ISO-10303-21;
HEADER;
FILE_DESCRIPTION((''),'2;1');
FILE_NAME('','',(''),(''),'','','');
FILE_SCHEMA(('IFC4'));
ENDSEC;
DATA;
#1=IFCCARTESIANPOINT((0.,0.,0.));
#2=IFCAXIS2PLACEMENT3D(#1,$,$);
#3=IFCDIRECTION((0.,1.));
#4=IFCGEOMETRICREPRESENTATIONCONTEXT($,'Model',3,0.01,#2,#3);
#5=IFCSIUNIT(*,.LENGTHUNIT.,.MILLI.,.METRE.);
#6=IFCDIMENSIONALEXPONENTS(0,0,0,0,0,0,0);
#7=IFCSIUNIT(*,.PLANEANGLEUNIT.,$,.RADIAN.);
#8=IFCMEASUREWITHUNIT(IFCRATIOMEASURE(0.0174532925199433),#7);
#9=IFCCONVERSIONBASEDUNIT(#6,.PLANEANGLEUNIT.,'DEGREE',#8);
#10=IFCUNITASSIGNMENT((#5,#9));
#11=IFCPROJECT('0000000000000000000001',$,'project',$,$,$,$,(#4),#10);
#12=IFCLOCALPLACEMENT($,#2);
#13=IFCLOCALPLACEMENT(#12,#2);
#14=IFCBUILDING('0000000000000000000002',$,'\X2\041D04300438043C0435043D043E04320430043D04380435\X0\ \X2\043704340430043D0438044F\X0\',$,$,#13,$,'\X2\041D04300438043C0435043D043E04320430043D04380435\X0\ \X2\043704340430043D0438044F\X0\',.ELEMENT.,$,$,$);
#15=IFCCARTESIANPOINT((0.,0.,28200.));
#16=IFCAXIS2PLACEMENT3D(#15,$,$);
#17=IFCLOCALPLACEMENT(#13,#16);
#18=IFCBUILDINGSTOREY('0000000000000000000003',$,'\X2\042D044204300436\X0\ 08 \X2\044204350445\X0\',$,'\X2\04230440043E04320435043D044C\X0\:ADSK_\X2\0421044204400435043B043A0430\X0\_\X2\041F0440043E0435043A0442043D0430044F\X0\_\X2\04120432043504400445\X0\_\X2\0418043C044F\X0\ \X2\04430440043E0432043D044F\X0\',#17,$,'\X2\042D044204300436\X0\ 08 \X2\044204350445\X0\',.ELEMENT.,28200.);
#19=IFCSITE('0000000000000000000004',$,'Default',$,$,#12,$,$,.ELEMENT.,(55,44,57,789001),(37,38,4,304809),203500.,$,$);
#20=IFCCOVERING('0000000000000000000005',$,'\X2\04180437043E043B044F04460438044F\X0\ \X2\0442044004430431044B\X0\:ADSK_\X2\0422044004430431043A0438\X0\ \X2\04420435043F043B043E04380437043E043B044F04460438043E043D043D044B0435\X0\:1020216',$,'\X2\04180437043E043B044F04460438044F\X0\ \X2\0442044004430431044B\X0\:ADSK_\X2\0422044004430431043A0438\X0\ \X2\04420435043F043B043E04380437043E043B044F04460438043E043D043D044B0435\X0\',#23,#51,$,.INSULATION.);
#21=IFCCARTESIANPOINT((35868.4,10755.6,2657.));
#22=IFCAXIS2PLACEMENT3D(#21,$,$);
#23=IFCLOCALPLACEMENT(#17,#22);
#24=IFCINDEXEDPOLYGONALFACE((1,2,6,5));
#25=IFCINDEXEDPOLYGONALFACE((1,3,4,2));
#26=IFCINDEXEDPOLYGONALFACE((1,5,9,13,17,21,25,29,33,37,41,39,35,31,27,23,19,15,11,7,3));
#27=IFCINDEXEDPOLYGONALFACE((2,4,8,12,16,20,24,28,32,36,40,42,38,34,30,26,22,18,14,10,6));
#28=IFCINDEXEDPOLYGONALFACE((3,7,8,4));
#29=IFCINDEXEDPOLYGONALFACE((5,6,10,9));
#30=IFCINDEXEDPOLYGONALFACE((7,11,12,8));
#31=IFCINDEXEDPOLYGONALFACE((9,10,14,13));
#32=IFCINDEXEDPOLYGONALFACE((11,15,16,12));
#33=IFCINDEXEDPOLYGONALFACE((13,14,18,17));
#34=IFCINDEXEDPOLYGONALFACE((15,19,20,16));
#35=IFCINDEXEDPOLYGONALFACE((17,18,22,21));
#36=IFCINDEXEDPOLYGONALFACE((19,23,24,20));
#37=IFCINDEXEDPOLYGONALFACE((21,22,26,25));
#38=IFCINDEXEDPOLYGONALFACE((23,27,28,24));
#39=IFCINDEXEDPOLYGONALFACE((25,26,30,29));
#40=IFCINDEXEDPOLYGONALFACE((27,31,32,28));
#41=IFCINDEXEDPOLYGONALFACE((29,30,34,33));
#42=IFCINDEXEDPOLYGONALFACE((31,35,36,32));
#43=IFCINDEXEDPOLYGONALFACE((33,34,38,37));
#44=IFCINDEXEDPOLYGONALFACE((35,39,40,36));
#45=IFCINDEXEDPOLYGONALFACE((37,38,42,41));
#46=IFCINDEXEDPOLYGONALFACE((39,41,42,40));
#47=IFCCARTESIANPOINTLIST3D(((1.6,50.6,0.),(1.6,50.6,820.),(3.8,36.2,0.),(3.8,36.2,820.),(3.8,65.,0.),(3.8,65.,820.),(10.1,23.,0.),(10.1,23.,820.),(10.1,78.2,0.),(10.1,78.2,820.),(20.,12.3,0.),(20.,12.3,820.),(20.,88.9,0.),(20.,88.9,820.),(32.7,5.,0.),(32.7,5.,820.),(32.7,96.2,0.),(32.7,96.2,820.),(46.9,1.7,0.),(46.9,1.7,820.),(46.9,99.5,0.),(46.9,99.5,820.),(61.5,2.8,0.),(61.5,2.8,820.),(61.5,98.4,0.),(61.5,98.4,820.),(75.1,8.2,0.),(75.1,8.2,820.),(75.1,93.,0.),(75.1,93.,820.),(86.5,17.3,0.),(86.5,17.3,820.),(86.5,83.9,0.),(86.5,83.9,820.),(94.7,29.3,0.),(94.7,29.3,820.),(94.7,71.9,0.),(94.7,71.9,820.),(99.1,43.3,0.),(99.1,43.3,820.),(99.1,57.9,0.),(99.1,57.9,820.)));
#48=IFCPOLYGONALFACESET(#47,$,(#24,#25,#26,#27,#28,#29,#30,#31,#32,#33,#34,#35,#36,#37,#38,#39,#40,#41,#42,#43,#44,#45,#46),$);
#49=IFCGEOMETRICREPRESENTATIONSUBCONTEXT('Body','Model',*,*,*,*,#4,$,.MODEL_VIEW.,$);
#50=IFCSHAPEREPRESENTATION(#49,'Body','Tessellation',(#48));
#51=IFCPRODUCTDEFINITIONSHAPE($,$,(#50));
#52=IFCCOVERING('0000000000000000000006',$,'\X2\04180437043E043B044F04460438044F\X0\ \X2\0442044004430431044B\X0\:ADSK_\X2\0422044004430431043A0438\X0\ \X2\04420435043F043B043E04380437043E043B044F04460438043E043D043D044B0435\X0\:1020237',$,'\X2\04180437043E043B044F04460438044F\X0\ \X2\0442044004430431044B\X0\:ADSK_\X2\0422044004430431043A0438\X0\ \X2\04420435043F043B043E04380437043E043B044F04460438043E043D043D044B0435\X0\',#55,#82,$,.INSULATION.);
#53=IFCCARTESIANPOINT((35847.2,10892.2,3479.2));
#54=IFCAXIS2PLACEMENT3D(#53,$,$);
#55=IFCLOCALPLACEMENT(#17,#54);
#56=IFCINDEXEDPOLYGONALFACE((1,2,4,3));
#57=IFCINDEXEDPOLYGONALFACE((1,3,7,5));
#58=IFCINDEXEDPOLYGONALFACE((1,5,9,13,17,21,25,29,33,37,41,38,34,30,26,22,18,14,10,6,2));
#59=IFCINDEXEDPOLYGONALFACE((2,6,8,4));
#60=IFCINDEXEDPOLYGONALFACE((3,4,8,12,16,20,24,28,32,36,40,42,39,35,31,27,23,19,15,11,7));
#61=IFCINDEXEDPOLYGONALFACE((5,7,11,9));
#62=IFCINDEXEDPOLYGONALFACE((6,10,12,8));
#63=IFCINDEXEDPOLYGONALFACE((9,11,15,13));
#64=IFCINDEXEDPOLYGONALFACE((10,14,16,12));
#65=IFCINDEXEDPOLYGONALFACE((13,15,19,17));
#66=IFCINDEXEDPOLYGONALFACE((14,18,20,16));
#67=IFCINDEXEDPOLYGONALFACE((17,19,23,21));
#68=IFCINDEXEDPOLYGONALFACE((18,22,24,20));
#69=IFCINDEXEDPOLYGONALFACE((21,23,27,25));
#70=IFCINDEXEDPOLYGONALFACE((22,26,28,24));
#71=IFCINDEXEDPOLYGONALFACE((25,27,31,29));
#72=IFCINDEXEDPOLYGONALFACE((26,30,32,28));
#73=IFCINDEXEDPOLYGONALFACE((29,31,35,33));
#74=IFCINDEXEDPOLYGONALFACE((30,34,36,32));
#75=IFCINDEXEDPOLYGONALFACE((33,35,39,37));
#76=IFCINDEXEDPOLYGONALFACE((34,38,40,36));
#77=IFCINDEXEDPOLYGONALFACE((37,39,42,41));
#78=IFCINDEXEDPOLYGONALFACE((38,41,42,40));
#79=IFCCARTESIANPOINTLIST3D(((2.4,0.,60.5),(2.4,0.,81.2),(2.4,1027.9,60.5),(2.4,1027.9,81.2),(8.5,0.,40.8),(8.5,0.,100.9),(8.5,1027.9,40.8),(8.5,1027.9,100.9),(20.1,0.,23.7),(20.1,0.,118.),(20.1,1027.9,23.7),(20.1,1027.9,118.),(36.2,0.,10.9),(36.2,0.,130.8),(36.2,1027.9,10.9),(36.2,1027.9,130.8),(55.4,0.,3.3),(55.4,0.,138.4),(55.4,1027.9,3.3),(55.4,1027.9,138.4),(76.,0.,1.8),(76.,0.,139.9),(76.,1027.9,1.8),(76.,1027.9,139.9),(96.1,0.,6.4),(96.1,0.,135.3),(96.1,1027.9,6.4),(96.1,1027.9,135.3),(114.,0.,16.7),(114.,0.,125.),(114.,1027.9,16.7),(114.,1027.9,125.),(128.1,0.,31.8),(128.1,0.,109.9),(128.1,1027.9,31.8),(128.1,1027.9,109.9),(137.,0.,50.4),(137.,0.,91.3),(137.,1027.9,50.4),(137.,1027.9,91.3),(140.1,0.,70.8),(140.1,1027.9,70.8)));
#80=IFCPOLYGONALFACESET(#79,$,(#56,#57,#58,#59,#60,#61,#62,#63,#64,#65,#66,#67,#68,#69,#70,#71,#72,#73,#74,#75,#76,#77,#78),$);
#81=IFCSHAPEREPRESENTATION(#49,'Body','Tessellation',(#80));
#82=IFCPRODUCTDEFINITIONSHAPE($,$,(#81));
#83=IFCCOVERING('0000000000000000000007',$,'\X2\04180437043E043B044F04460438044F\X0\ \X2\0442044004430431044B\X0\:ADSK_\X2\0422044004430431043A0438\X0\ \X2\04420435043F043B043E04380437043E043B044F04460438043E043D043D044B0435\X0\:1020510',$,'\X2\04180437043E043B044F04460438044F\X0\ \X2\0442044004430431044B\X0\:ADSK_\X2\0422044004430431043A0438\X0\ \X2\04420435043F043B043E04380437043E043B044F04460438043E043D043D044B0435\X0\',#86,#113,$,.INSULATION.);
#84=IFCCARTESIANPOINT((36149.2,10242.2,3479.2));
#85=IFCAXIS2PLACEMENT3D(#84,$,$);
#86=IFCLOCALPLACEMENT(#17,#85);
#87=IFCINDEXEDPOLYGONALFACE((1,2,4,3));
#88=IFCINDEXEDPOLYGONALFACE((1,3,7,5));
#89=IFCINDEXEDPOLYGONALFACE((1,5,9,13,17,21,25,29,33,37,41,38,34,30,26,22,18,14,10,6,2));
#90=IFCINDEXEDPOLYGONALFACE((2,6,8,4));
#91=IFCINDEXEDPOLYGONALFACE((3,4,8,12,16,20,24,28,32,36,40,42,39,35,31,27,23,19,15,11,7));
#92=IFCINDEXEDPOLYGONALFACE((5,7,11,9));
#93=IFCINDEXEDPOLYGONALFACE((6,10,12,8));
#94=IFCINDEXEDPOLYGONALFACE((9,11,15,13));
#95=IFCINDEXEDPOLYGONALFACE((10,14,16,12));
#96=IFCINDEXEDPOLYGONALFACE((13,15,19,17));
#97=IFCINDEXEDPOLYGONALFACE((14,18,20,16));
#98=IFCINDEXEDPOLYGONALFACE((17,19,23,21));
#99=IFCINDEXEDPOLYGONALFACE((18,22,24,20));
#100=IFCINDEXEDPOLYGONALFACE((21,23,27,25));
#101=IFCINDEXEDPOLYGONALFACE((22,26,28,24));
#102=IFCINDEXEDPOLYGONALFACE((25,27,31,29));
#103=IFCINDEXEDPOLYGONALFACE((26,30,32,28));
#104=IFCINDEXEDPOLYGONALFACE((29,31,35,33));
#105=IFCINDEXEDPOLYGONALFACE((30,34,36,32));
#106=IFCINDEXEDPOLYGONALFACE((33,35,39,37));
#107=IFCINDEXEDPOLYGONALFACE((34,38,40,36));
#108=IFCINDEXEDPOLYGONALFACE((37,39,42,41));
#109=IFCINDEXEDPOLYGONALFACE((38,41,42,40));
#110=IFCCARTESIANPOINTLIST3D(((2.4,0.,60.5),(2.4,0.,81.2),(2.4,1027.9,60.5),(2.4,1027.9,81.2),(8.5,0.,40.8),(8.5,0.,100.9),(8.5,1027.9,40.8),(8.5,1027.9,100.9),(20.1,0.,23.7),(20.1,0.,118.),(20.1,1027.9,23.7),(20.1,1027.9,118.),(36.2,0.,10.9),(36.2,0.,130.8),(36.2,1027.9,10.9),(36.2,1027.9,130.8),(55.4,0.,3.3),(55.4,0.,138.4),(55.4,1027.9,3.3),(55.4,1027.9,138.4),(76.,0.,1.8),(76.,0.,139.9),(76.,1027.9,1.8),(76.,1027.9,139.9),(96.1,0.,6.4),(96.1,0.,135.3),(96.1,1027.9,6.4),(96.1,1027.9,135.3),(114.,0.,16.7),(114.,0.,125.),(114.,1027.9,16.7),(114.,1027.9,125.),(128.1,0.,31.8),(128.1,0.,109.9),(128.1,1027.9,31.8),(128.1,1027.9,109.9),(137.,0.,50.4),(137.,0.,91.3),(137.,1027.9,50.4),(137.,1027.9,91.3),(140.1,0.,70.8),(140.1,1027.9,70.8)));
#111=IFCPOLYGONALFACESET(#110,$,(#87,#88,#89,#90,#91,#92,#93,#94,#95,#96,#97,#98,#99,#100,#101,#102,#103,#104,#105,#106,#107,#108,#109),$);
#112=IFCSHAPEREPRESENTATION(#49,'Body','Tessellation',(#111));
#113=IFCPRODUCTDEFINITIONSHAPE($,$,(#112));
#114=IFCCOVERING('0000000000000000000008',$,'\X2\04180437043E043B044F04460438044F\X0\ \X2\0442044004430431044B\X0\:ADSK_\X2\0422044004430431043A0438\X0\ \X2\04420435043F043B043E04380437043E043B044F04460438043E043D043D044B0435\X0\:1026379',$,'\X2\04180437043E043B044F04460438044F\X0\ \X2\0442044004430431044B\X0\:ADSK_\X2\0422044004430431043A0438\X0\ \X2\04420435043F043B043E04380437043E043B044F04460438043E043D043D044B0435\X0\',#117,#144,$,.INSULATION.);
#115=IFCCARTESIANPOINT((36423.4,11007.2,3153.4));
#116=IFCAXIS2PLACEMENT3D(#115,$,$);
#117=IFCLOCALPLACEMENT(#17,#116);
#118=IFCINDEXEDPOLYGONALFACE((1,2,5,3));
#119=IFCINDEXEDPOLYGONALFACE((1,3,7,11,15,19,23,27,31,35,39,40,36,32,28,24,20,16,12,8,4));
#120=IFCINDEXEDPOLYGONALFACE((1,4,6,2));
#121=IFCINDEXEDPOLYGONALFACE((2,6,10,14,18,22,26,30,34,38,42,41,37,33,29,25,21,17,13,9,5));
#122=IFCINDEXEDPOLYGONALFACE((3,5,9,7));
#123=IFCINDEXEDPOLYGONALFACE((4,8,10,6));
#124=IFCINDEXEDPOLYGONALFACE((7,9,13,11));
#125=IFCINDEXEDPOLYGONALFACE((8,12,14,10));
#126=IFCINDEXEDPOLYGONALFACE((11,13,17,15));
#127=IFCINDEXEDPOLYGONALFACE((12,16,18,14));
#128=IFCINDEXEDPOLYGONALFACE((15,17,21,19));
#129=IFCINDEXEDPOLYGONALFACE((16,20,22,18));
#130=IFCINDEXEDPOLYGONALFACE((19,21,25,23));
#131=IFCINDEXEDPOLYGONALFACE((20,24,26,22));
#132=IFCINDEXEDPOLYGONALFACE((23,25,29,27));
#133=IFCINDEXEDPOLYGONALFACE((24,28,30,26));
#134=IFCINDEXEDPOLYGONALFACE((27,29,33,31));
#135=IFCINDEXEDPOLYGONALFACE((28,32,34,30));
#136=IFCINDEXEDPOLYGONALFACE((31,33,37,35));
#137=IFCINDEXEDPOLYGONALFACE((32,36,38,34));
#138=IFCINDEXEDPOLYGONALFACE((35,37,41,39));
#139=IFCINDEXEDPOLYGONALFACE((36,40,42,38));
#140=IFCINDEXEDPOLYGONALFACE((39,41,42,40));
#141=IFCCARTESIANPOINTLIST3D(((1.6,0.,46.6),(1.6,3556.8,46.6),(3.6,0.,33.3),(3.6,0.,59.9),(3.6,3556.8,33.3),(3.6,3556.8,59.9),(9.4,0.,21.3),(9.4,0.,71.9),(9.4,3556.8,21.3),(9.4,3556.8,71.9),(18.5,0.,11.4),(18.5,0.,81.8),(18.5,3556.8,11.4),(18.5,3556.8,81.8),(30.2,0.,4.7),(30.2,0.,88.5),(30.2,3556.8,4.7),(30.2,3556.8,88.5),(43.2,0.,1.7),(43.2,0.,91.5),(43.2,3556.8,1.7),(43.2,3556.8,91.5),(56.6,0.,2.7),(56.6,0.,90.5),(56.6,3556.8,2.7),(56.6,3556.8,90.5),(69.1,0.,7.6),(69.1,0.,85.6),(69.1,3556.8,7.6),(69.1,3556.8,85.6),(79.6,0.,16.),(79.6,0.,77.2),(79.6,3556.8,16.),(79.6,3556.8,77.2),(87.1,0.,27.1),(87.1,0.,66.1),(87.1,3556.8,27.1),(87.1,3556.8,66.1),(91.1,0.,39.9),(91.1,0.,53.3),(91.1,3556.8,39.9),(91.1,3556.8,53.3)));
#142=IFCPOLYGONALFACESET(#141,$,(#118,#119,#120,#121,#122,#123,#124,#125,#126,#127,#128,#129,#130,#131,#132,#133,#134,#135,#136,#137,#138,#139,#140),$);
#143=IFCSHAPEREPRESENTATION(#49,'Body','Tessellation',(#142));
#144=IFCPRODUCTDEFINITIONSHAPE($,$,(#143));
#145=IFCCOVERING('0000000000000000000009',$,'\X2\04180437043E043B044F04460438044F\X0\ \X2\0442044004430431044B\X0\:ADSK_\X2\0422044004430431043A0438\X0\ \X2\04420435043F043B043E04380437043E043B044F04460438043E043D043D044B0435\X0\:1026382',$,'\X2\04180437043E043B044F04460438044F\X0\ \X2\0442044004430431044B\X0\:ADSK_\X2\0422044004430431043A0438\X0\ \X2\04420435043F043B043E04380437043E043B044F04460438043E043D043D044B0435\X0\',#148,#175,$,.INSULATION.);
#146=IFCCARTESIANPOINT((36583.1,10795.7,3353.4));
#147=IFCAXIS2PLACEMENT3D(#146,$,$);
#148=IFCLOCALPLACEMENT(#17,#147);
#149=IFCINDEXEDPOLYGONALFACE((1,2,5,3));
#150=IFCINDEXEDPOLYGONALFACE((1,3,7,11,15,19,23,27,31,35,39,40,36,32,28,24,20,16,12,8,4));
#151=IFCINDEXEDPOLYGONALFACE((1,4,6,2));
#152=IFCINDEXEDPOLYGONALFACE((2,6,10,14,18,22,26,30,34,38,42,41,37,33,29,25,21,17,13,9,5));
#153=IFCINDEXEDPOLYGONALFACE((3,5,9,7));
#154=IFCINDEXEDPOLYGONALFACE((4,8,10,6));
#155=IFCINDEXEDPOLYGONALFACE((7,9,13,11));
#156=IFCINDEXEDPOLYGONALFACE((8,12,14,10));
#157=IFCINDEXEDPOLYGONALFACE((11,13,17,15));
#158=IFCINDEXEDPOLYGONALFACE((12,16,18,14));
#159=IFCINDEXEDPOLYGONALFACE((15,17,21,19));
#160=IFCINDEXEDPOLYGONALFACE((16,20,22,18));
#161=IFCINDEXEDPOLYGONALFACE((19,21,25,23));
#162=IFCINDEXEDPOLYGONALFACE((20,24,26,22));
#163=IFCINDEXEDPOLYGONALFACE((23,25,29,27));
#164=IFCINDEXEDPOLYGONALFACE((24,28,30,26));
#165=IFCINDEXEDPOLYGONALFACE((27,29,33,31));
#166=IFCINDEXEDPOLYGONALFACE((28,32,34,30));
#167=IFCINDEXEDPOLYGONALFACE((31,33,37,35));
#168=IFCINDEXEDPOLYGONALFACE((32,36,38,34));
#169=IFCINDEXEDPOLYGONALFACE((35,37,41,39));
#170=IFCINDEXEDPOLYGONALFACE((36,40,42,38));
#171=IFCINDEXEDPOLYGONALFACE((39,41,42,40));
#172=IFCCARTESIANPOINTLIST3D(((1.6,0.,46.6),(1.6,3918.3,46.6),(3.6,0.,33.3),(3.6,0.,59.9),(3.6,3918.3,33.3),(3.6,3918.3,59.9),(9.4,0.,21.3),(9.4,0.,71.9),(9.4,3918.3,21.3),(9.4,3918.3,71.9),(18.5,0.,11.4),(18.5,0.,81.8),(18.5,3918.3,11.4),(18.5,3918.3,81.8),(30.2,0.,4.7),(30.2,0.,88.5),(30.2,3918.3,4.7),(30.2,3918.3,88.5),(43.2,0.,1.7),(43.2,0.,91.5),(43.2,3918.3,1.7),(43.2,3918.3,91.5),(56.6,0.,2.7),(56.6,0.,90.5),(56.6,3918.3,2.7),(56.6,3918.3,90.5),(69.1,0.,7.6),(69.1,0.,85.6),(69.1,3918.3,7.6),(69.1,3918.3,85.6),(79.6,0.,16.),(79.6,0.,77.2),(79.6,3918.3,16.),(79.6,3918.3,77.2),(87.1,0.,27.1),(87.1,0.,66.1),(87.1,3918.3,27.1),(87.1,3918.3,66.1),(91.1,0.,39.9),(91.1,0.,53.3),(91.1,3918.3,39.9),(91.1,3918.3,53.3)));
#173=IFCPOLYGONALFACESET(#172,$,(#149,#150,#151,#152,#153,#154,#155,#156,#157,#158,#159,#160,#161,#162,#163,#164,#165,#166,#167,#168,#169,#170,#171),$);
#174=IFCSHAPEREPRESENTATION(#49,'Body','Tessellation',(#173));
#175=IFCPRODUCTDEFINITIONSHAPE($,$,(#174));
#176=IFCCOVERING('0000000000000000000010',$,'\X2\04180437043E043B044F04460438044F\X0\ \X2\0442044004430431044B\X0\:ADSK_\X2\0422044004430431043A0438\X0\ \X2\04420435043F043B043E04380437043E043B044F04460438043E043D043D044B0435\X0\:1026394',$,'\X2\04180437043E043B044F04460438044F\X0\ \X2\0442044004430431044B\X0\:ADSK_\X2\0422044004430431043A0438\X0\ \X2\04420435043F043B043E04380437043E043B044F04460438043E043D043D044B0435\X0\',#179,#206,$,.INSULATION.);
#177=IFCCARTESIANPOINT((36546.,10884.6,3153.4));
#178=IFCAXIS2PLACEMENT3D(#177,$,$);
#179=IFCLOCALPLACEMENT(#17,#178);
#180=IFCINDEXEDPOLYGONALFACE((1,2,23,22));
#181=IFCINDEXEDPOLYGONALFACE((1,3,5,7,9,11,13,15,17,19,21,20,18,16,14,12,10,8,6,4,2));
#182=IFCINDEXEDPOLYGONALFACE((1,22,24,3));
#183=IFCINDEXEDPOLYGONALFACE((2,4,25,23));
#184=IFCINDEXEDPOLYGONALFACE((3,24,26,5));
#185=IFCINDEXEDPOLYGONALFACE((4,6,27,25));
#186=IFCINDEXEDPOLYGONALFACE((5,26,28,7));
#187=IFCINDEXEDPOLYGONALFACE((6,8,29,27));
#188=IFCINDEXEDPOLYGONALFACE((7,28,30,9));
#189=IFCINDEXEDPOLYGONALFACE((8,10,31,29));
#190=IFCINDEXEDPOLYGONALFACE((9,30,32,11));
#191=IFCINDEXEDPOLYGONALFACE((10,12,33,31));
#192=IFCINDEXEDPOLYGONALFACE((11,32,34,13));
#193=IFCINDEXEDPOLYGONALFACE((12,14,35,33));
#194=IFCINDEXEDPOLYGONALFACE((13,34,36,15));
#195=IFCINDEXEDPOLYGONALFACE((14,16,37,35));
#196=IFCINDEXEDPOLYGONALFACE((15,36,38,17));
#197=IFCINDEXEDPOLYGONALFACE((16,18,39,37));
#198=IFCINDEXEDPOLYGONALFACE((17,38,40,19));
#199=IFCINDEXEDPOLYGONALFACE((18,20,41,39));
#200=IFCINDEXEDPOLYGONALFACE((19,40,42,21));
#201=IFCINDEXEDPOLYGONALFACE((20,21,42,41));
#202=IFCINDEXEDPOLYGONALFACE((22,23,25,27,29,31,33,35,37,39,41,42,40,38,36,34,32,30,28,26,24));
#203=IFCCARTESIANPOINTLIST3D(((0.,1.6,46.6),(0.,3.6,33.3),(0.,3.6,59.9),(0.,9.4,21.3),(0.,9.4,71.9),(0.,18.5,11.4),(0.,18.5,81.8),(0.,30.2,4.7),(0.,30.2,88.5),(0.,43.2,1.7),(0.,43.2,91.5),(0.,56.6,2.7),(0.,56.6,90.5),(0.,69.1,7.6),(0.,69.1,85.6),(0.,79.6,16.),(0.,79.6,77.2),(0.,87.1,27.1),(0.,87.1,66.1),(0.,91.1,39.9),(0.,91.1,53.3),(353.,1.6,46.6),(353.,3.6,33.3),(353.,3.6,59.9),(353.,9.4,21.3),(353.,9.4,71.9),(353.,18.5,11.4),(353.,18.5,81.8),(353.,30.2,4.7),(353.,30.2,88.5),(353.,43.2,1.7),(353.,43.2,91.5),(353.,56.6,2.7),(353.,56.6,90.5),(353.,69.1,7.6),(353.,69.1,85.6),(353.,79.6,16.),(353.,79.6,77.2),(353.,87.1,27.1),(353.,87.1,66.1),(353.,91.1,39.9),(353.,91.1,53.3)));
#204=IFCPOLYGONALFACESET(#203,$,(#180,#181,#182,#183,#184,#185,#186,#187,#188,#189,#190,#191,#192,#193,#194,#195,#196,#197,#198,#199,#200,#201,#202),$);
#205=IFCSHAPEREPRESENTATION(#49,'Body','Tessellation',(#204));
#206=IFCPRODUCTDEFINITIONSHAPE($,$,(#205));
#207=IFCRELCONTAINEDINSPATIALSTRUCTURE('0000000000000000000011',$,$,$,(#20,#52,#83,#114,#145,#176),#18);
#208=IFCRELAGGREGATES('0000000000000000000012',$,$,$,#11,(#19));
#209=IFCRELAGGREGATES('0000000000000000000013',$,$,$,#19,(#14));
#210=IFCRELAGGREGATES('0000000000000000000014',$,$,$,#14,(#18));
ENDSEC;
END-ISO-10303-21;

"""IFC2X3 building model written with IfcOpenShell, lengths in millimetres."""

from ifc_helpers import new_model, entity, si_unit, converted_unit, direction, frame, origin, origin_2d_with_axis, place, context, subcontext, project, spatial, circle, extrude, element, save


model = new_model("IFC2X3")

# Units and contexts
model_context = context("Model", 3, precision=0.01, world=origin(), true_north=direction((0.0, 1.0)))
body_context = subcontext(model_context, "Body", "Model", "MODEL_VIEW")
ifc_project = project(units=[si_unit("LENGTHUNIT", "METRE", prefix="MILLI"), converted_unit("PLANEANGLEUNIT", "DEGREE", entity("IfcRatioMeasure", 0.0174532925199433), si_unit("PLANEANGLEUNIT", "RADIAN"), dimensions=[0, 0, 0, 0, 0, 0, 0])], contexts=[model_context])

# Site, building, storey
site_placement = place(None, origin())
site = spatial("IfcSite", under=ifc_project, at=site_placement, Name="Default", CompositionType="ELEMENT", RefLatitude=(55, 44, 57, 789001), RefLongitude=(37, 38, 4, 304809), RefElevation=203500.0)
building_placement = place(site_placement, origin())
building = spatial("IfcBuilding", under=site, at=building_placement, Name="Наименование здания", LongName="Наименование здания", CompositionType="ELEMENT")
storey_placement = place(building_placement, frame((0.0, 0.0, 28200.0)))
storey = spatial("IfcBuildingStorey", under=building, at=storey_placement, Name="Этаж 08 тех", ObjectType="Уровень:ADSK_Стрелка_Проектная_Вверх_Имя уровня", LongName="Этаж 08 тех", CompositionType="ELEMENT", Elevation=28200.0)

# Coverings
covering_1_placement = place(storey_placement, frame((35868.4, 10755.6, 2657.0)))
element("IfcCovering", 1, at=covering_1_placement, inside=storey, Name="Изоляция трубы:ADSK_Трубки теплоизоляционные:1020216", ObjectType="Изоляция трубы:ADSK_Трубки теплоизоляционные", PredefinedType="INSULATION", context=body_context, shape_type="SweptSolid", body=[
    extrude(circle(Radius=49.0, at=origin_2d_with_axis()), frame((50.6, 50.6, 0.0), z_axis=(0.0, 0.0, 1.0), x_axis=(-1.0, 0.0, 0.0)), (0.0, 0.0, 1.0), 820.0),
])
covering_2_placement = place(storey_placement, frame((35847.2, 10892.2, 3479.2)))
element("IfcCovering", 2, at=covering_2_placement, inside=storey, Name="Изоляция трубы:ADSK_Трубки теплоизоляционные:1020237", ObjectType="Изоляция трубы:ADSK_Трубки теплоизоляционные", PredefinedType="INSULATION", context=body_context, shape_type="SweptSolid", body=[
    extrude(circle(Radius=69.2, at=origin_2d_with_axis()), frame((70.8, 0.0, 70.8), z_axis=(0.0, 1.0, 0.0), x_axis=(1.0, 0.0, 0.0)), (0.0, 0.0, 1.0), 1027.9),
])
covering_3_placement = place(storey_placement, frame((36149.2, 10242.2, 3479.2)))
element("IfcCovering", 3, at=covering_3_placement, inside=storey, Name="Изоляция трубы:ADSK_Трубки теплоизоляционные:1020510", ObjectType="Изоляция трубы:ADSK_Трубки теплоизоляционные", PredefinedType="INSULATION", context=body_context, shape_type="SweptSolid", body=[
    extrude(circle(Radius=69.2, at=origin_2d_with_axis()), frame((70.8, 0.0, 70.8), z_axis=(0.0, 1.0, 0.0), x_axis=(1.0, 0.0, 0.0)), (0.0, 0.0, 1.0), 1027.9),
])
covering_4_placement = place(storey_placement, frame((36423.4, 11007.2, 3153.4)))
element("IfcCovering", 4, at=covering_4_placement, inside=storey, Name="Изоляция трубы:ADSK_Трубки теплоизоляционные:1026379", ObjectType="Изоляция трубы:ADSK_Трубки теплоизоляционные", PredefinedType="INSULATION", context=body_context, shape_type="SweptSolid", body=[
    extrude(circle(Radius=45.0, at=origin_2d_with_axis()), frame((46.6, 0.0, 46.6), z_axis=(0.0, 1.0, 0.0), x_axis=(-1.0, 0.0, 0.0)), (0.0, 0.0, 1.0), 3556.8),
])
covering_5_placement = place(storey_placement, frame((36583.1, 10795.7, 3353.4)))
element("IfcCovering", 5, at=covering_5_placement, inside=storey, Name="Изоляция трубы:ADSK_Трубки теплоизоляционные:1026382", ObjectType="Изоляция трубы:ADSK_Трубки теплоизоляционные", PredefinedType="INSULATION", context=body_context, shape_type="SweptSolid", body=[
    extrude(circle(Radius=45.0, at=origin_2d_with_axis()), frame((46.6, 0.0, 46.6), z_axis=(0.0, 1.0, 0.0), x_axis=(-1.0, 0.0, 0.0)), (0.0, 0.0, 1.0), 3918.3),
])
covering_6_placement = place(storey_placement, frame((36546.0, 10884.6, 3153.4)))
element("IfcCovering", 6, at=covering_6_placement, inside=storey, Name="Изоляция трубы:ADSK_Трубки теплоизоляционные:1026394", ObjectType="Изоляция трубы:ADSK_Трубки теплоизоляционные", PredefinedType="INSULATION", context=body_context, shape_type="SweptSolid", body=[
    extrude(circle(Radius=45.0, at=origin_2d_with_axis()), frame((0.0, 46.6, 46.6), z_axis=(1.0, 0.0, 0.0), x_axis=(0.0, -1.0, 0.0)), (0.0, 0.0, 1.0), 353.0),
])

save(model, "model.ifc")
